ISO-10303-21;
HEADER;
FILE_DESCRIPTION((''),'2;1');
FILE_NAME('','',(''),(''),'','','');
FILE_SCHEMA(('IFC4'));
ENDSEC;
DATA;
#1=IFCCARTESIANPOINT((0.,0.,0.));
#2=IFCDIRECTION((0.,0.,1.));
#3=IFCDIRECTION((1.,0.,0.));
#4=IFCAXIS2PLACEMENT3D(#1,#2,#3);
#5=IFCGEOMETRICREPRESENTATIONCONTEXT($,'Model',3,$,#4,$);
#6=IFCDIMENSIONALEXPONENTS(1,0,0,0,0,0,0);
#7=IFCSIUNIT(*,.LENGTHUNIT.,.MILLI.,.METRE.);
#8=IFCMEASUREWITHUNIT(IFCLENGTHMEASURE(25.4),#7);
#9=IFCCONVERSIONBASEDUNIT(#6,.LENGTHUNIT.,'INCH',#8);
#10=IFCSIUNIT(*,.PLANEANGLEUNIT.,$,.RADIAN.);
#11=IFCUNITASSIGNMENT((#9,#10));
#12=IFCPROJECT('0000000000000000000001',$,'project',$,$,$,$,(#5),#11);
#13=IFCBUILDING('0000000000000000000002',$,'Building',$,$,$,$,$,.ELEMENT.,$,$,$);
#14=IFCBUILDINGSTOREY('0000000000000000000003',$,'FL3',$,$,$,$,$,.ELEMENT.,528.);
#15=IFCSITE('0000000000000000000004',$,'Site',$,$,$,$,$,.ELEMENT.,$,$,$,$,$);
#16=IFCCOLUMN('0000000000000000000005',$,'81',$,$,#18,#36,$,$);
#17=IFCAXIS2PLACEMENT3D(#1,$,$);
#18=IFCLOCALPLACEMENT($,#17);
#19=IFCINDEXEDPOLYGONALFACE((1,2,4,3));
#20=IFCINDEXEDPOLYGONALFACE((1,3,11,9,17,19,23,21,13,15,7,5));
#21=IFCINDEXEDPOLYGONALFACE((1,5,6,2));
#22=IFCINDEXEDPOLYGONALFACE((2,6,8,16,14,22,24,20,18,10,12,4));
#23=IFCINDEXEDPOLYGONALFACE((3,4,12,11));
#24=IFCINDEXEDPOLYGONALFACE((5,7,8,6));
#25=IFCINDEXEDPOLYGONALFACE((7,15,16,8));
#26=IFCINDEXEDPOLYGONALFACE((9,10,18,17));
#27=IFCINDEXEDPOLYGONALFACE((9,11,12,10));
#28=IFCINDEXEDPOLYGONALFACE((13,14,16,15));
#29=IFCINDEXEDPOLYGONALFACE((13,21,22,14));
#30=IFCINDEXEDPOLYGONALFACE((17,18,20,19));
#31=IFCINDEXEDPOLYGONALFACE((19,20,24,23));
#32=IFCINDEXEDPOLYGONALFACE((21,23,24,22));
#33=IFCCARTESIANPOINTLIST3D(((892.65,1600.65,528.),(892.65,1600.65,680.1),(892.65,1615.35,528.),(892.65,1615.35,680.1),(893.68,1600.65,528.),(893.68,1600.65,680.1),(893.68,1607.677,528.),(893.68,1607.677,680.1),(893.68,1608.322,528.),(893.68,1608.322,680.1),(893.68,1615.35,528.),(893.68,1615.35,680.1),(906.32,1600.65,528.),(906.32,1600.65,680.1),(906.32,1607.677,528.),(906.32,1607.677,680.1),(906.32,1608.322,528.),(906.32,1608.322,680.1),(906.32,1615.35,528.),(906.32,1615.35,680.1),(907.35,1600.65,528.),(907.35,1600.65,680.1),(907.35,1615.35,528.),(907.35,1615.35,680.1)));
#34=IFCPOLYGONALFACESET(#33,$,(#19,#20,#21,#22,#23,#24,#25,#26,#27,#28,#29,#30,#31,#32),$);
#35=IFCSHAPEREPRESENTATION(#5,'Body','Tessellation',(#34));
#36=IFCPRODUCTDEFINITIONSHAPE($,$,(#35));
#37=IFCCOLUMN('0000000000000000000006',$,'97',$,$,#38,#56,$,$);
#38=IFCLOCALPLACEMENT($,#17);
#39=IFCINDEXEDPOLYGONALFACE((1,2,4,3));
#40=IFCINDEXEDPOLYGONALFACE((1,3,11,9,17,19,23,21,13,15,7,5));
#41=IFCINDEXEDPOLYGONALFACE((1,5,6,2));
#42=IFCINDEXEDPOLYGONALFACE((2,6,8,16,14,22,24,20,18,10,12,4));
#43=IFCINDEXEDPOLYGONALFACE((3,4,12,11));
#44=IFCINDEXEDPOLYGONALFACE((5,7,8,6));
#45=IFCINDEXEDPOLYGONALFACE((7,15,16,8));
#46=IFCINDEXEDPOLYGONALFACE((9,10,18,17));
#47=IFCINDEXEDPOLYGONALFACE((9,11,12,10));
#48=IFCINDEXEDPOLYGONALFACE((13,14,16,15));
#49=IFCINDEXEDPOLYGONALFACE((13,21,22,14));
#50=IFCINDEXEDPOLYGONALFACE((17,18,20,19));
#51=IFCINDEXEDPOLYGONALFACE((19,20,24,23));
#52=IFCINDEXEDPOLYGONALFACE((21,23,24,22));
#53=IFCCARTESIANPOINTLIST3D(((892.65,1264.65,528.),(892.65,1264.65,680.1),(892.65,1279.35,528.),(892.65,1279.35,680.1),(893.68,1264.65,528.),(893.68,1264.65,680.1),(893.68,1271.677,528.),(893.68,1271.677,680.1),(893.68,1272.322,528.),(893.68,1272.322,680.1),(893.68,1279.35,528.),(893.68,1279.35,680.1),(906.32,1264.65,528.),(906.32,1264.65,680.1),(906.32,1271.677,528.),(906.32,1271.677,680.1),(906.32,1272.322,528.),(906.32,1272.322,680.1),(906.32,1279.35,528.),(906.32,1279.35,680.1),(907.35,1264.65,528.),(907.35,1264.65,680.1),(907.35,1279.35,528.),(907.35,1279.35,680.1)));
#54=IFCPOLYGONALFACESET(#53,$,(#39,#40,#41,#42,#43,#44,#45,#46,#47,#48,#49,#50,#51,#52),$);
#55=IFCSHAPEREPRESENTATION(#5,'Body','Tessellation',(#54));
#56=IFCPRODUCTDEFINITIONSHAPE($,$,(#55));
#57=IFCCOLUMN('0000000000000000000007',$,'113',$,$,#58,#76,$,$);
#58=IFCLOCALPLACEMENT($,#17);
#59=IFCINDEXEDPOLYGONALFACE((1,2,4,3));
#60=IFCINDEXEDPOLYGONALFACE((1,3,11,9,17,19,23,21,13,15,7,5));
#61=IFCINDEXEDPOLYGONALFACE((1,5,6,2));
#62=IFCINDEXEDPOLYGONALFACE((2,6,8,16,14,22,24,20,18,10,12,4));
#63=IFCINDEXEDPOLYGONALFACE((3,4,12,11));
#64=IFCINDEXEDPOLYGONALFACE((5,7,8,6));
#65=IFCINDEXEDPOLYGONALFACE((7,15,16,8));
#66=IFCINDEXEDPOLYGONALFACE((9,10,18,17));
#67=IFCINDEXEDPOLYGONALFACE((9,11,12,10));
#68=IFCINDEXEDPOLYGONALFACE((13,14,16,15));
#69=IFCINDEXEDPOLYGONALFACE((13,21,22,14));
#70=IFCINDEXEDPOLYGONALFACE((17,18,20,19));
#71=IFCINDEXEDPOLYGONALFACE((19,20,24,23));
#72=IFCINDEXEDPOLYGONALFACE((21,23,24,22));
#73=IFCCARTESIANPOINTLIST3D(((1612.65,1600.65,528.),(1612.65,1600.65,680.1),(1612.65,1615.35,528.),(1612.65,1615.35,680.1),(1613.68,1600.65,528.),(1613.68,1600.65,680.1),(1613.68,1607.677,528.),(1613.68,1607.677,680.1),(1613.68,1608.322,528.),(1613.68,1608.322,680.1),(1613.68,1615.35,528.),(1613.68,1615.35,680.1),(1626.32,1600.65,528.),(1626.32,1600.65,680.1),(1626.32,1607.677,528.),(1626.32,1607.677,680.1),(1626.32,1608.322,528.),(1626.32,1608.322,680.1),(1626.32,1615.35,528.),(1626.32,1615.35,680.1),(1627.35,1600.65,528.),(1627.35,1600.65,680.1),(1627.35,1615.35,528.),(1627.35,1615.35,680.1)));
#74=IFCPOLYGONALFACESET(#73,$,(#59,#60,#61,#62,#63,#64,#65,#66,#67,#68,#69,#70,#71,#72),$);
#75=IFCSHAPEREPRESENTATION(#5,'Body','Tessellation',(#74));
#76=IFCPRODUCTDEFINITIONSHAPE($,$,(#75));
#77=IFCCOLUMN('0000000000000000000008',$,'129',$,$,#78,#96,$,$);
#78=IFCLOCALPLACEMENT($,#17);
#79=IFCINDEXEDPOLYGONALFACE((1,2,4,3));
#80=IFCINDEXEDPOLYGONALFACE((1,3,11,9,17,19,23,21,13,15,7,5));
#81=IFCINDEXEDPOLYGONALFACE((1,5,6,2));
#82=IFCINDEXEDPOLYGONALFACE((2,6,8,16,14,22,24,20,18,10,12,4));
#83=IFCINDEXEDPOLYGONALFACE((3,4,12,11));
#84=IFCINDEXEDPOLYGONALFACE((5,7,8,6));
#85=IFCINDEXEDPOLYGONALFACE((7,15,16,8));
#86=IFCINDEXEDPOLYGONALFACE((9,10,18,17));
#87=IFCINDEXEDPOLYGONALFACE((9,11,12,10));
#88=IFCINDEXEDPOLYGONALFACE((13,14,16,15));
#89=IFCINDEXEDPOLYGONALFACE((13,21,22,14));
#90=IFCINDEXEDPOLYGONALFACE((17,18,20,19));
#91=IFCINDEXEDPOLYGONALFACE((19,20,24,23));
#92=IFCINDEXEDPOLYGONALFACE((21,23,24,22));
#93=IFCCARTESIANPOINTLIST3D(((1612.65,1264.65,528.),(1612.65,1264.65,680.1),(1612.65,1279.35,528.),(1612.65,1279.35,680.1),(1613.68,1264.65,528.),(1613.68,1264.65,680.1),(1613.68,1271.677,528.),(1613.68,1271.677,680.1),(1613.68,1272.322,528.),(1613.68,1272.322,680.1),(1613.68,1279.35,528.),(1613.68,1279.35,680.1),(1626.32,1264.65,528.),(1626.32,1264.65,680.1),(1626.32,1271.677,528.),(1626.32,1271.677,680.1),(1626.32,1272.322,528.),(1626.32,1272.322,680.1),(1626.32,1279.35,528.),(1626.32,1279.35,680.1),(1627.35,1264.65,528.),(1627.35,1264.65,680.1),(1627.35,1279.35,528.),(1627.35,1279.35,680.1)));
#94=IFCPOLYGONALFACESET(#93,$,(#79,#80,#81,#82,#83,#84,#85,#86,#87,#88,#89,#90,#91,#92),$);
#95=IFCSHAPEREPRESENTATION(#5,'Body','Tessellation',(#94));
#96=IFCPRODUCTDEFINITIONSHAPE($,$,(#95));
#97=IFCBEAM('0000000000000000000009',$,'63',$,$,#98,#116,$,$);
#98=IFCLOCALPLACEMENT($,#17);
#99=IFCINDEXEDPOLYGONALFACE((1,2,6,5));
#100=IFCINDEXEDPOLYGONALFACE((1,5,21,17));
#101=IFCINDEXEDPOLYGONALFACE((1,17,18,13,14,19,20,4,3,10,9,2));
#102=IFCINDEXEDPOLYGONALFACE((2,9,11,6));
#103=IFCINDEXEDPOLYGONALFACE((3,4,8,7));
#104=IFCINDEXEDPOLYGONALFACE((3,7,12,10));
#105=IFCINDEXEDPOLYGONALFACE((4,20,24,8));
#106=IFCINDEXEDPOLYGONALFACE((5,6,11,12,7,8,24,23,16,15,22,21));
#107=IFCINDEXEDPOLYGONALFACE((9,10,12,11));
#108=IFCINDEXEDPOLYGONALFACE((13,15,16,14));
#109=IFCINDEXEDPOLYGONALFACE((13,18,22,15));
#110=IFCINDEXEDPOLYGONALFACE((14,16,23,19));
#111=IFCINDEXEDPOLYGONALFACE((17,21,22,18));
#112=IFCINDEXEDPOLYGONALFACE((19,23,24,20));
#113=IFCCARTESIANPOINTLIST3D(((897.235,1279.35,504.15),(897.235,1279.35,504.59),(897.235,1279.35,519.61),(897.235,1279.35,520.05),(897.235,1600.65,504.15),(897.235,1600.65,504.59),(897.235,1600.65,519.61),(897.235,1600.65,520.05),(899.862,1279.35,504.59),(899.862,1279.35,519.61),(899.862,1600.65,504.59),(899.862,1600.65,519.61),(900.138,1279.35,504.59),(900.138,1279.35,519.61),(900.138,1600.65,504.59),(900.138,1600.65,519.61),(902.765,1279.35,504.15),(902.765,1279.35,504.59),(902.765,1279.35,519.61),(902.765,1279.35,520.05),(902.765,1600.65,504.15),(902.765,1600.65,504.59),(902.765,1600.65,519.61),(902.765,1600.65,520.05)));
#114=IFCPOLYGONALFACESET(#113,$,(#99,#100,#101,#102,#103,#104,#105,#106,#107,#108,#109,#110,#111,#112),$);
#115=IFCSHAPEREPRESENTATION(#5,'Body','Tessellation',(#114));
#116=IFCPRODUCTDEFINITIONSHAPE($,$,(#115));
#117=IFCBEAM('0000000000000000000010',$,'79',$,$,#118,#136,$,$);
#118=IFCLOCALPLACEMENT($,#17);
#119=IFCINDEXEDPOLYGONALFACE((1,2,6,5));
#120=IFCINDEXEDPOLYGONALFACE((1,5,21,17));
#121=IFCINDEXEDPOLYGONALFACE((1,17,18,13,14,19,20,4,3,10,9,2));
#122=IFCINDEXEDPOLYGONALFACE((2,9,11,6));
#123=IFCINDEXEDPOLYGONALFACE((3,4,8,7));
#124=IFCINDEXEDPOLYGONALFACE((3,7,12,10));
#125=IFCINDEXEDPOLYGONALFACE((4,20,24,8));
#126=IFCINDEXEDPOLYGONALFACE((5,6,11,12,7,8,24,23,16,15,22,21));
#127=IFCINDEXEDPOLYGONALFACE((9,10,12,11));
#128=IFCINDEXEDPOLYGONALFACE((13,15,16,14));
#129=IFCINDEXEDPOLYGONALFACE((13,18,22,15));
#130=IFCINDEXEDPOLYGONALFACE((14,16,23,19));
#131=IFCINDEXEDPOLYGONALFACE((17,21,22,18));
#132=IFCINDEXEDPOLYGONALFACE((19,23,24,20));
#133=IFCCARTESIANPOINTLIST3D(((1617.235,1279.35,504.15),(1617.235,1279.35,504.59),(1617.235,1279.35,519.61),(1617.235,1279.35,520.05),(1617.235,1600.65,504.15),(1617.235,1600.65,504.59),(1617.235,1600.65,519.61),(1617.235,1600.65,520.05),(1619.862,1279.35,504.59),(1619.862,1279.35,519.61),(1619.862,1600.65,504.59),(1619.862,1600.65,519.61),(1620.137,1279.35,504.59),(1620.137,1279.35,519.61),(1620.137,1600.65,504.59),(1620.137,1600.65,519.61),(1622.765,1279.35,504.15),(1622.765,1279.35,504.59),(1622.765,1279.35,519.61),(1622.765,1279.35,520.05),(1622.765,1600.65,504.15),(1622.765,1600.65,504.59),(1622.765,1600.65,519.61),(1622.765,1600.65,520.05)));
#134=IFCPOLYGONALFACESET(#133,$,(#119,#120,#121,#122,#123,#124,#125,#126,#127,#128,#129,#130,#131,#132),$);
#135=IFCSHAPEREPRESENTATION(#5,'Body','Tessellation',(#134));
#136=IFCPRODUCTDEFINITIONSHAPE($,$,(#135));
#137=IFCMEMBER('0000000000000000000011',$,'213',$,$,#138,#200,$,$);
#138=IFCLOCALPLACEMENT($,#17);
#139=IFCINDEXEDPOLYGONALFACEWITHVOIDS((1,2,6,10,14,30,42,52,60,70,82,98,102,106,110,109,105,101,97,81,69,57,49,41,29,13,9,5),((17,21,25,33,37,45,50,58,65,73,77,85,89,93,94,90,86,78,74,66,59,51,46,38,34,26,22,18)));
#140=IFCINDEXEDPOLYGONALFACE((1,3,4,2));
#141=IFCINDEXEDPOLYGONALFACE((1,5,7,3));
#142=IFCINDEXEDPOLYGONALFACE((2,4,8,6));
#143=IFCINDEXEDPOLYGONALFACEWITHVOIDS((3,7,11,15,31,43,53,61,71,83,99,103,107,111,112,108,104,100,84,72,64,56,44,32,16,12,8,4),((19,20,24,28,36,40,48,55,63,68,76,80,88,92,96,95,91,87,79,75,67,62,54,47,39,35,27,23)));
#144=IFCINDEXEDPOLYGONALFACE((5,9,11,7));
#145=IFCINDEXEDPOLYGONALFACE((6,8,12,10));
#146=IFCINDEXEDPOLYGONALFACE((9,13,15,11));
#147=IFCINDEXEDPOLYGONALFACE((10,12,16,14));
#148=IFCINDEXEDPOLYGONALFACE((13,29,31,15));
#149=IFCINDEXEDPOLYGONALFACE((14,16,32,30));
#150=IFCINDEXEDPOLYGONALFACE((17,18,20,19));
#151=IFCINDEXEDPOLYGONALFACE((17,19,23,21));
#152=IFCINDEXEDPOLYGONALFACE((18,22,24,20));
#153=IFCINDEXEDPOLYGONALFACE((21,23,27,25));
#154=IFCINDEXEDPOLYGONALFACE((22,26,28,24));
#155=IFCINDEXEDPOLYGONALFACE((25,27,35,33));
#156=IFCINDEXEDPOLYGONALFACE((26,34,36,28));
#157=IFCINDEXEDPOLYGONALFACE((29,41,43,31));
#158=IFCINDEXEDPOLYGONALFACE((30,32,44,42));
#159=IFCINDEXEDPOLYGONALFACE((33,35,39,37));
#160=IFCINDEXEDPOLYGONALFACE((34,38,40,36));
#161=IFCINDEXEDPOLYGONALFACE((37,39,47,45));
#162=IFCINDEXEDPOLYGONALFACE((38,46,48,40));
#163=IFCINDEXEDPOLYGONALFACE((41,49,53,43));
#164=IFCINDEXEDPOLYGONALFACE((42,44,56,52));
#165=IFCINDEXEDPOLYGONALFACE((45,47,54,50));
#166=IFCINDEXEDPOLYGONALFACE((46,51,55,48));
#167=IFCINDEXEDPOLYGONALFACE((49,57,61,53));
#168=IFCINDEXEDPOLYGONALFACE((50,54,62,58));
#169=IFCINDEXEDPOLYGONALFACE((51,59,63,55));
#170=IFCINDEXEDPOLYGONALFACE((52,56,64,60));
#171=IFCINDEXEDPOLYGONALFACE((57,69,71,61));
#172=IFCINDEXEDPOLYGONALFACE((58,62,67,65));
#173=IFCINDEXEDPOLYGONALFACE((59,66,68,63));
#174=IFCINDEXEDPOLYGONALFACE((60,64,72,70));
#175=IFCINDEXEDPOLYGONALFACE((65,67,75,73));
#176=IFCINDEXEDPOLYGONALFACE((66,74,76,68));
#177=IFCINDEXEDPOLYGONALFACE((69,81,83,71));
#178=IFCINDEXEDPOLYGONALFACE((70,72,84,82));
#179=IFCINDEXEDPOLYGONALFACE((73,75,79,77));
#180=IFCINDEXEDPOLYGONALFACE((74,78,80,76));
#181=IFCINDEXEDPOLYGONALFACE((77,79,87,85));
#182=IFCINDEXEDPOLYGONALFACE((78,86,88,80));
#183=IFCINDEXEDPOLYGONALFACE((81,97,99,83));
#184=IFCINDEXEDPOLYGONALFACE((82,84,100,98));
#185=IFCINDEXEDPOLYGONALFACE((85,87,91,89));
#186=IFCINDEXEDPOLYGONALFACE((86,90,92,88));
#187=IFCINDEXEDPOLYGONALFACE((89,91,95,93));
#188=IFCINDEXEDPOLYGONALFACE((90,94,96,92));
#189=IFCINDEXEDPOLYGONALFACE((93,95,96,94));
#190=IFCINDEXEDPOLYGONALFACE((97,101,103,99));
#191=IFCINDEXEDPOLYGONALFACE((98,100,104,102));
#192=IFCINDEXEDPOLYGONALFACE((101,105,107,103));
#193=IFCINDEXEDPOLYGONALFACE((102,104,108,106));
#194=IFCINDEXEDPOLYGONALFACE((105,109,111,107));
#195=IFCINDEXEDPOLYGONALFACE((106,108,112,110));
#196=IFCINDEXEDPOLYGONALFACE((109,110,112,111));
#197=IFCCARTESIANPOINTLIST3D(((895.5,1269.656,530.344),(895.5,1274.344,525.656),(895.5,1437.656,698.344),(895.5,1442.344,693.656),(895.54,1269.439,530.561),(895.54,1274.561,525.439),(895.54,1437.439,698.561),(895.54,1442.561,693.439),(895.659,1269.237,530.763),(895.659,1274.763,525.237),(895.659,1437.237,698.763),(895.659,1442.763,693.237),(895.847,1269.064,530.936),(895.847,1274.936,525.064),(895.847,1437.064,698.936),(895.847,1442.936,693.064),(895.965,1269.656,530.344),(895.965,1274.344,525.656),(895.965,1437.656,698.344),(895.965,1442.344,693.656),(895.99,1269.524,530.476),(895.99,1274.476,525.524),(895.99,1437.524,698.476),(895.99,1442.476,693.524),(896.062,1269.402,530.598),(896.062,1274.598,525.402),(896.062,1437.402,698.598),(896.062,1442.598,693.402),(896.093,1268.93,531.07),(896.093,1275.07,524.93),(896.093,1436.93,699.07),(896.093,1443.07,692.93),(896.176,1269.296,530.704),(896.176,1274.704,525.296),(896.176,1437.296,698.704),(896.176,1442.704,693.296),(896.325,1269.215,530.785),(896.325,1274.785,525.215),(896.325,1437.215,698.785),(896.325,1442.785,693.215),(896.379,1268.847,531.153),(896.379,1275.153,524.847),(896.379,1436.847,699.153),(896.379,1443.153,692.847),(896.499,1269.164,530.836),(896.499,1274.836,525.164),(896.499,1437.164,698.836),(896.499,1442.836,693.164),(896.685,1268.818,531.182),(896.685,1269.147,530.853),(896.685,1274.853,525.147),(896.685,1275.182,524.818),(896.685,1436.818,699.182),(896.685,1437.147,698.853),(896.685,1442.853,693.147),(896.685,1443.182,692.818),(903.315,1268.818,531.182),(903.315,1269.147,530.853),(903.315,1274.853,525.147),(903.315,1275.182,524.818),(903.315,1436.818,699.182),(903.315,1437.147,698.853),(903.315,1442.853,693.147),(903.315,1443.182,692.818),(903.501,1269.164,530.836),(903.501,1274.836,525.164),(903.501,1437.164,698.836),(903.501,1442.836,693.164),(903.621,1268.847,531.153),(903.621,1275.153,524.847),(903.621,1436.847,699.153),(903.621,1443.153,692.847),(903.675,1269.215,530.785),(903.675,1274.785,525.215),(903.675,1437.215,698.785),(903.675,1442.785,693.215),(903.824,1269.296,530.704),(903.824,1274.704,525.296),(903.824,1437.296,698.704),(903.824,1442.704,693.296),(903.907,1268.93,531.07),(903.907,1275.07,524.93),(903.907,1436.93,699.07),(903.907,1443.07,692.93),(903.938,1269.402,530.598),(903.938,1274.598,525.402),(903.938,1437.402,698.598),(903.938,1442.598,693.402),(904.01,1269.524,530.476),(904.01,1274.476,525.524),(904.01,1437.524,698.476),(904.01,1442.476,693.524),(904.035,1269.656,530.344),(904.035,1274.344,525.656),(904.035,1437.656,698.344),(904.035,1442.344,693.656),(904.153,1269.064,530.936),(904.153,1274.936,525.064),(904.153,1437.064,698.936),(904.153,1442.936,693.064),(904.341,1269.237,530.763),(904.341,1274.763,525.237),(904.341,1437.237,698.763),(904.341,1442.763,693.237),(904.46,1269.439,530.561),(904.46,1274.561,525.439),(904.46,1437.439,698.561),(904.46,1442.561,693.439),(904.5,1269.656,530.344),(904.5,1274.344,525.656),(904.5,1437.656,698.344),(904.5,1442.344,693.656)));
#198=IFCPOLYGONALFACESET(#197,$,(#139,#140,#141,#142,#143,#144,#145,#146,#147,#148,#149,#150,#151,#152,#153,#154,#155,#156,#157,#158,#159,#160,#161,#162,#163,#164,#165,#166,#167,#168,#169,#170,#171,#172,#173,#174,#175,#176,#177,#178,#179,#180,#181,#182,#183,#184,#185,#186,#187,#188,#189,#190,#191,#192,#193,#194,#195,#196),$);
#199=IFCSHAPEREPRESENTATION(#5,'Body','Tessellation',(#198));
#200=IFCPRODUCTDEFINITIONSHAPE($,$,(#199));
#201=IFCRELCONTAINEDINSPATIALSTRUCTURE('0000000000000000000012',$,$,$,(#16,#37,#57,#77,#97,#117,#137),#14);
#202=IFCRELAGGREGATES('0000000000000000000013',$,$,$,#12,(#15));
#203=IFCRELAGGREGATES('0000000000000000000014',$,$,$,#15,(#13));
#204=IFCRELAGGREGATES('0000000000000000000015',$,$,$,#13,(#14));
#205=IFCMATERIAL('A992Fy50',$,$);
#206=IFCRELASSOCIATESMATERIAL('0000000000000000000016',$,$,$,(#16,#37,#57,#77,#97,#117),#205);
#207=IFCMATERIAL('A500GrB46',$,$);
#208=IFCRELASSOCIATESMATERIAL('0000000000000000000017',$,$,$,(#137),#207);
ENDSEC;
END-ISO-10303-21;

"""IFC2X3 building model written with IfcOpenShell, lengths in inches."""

from ifc_helpers import new_model, entity, si_unit, converted_unit, frame, origin_with_axes, origin_2d_with_axis, place, context, project, spatial, hollow_rectangle, i_section, transform_2d, derived_profile, extrude, material, element, save


model = new_model("IFC2X3")

# Units and contexts
model_context = context("Model", 3, world=origin_with_axes())
ifc_project = project(units=[converted_unit("LENGTHUNIT", "INCH", entity("IfcLengthMeasure", 25.4), si_unit("LENGTHUNIT", "METRE", prefix="MILLI"), dimensions=[1, 0, 0, 0, 0, 0, 0]), si_unit("PLANEANGLEUNIT", "RADIAN")], contexts=[model_context])

# Site, building, storey
site = spatial("IfcSite", under=ifc_project, Name="Site", CompositionType="ELEMENT")
building = spatial("IfcBuilding", under=site, Name="Building", CompositionType="ELEMENT")
storey = spatial("IfcBuildingStorey", under=building, Name="FL3", CompositionType="ELEMENT", Elevation=528.0)

# Columns
ifc_material_1 = material(Name="A992Fy50")
for number, where, z_axis, x_axis, name in (
    (1, (900.0, 1608.0, 528.0), (0.0, 0.0, 1.0), (0.0, -1.0, 0.0), "81"),
    (2, (900.0, 1272.0, 528.0), (0.0, 0.0, 1.0), (0.0, -1.0, 0.0), "97"),
    (3, (1620.0, 1608.0, 528.0), (0.0, 0.0, 1.0), (0.0, -1.0, 0.0), "113"),
    (4, (1620.0, 1272.0, 528.0), (0.0, 0.0, 1.0), (0.0, -1.0, 0.0), "129"),
):
    element("IfcColumn", number, at=place(None, frame(where, z_axis=z_axis, x_axis=x_axis)), inside=storey, material=ifc_material_1, Name=name, context=model_context, shape_type="SweptSolid", body=[
        extrude(i_section(OverallWidth=14.7, OverallDepth=14.7, WebThickness=0.645, FlangeThickness=1.03, at=origin_2d_with_axis()), origin_with_axes(), (0.0, 0.0, 1.0), 152.1),
    ])

# Beams
for number, where, z_axis, x_axis, name in (
    (5, (900.0, 1279.35, 528.0), (0.0, 1.0, 0.0), (-1.0, 0.0, 0.0), "63"),
    (6, (1620.0, 1279.35, 528.0), (0.0, 1.0, 0.0), (-1.0, 0.0, 0.0), "79"),
):
    element("IfcBeam", number, at=place(None, frame(where, z_axis=z_axis, x_axis=x_axis)), inside=storey, material=ifc_material_1, Name=name, context=model_context, shape_type="SweptSolid", body=[
        extrude(derived_profile(i_section(OverallWidth=5.53, OverallDepth=15.9, WebThickness=0.275, FlangeThickness=0.44, at=origin_2d_with_axis()), transform_2d((0.0, -7.95))), origin_with_axes(), (0.0, 0.0, 1.0), 321.3),
    ])

# Member
ifc_material_2 = material(Name="A500GrB46")
for number, where, z_axis, x_axis, name in (
    (7, (900.0, 1272.0, 528.0), (0.0, 0.707107, 0.707107), (-1.0, 0.0, 0.0), "213"),
):
    element("IfcMember", number, at=place(None, frame(where, z_axis=z_axis, x_axis=x_axis)), inside=storey, material=ifc_material_2, Name=name, context=model_context, shape_type="SweptSolid", body=[
        extrude(hollow_rectangle(XDim=9.0, YDim=9.0, WallThickness=0.465, InnerFilletRadius=0.72, OuterFilletRadius=1.185, at=origin_2d_with_axis()), origin_with_axes(), (0.0, 0.0, 1.0), 237.588),
    ])

save(model, "model.ifc")
